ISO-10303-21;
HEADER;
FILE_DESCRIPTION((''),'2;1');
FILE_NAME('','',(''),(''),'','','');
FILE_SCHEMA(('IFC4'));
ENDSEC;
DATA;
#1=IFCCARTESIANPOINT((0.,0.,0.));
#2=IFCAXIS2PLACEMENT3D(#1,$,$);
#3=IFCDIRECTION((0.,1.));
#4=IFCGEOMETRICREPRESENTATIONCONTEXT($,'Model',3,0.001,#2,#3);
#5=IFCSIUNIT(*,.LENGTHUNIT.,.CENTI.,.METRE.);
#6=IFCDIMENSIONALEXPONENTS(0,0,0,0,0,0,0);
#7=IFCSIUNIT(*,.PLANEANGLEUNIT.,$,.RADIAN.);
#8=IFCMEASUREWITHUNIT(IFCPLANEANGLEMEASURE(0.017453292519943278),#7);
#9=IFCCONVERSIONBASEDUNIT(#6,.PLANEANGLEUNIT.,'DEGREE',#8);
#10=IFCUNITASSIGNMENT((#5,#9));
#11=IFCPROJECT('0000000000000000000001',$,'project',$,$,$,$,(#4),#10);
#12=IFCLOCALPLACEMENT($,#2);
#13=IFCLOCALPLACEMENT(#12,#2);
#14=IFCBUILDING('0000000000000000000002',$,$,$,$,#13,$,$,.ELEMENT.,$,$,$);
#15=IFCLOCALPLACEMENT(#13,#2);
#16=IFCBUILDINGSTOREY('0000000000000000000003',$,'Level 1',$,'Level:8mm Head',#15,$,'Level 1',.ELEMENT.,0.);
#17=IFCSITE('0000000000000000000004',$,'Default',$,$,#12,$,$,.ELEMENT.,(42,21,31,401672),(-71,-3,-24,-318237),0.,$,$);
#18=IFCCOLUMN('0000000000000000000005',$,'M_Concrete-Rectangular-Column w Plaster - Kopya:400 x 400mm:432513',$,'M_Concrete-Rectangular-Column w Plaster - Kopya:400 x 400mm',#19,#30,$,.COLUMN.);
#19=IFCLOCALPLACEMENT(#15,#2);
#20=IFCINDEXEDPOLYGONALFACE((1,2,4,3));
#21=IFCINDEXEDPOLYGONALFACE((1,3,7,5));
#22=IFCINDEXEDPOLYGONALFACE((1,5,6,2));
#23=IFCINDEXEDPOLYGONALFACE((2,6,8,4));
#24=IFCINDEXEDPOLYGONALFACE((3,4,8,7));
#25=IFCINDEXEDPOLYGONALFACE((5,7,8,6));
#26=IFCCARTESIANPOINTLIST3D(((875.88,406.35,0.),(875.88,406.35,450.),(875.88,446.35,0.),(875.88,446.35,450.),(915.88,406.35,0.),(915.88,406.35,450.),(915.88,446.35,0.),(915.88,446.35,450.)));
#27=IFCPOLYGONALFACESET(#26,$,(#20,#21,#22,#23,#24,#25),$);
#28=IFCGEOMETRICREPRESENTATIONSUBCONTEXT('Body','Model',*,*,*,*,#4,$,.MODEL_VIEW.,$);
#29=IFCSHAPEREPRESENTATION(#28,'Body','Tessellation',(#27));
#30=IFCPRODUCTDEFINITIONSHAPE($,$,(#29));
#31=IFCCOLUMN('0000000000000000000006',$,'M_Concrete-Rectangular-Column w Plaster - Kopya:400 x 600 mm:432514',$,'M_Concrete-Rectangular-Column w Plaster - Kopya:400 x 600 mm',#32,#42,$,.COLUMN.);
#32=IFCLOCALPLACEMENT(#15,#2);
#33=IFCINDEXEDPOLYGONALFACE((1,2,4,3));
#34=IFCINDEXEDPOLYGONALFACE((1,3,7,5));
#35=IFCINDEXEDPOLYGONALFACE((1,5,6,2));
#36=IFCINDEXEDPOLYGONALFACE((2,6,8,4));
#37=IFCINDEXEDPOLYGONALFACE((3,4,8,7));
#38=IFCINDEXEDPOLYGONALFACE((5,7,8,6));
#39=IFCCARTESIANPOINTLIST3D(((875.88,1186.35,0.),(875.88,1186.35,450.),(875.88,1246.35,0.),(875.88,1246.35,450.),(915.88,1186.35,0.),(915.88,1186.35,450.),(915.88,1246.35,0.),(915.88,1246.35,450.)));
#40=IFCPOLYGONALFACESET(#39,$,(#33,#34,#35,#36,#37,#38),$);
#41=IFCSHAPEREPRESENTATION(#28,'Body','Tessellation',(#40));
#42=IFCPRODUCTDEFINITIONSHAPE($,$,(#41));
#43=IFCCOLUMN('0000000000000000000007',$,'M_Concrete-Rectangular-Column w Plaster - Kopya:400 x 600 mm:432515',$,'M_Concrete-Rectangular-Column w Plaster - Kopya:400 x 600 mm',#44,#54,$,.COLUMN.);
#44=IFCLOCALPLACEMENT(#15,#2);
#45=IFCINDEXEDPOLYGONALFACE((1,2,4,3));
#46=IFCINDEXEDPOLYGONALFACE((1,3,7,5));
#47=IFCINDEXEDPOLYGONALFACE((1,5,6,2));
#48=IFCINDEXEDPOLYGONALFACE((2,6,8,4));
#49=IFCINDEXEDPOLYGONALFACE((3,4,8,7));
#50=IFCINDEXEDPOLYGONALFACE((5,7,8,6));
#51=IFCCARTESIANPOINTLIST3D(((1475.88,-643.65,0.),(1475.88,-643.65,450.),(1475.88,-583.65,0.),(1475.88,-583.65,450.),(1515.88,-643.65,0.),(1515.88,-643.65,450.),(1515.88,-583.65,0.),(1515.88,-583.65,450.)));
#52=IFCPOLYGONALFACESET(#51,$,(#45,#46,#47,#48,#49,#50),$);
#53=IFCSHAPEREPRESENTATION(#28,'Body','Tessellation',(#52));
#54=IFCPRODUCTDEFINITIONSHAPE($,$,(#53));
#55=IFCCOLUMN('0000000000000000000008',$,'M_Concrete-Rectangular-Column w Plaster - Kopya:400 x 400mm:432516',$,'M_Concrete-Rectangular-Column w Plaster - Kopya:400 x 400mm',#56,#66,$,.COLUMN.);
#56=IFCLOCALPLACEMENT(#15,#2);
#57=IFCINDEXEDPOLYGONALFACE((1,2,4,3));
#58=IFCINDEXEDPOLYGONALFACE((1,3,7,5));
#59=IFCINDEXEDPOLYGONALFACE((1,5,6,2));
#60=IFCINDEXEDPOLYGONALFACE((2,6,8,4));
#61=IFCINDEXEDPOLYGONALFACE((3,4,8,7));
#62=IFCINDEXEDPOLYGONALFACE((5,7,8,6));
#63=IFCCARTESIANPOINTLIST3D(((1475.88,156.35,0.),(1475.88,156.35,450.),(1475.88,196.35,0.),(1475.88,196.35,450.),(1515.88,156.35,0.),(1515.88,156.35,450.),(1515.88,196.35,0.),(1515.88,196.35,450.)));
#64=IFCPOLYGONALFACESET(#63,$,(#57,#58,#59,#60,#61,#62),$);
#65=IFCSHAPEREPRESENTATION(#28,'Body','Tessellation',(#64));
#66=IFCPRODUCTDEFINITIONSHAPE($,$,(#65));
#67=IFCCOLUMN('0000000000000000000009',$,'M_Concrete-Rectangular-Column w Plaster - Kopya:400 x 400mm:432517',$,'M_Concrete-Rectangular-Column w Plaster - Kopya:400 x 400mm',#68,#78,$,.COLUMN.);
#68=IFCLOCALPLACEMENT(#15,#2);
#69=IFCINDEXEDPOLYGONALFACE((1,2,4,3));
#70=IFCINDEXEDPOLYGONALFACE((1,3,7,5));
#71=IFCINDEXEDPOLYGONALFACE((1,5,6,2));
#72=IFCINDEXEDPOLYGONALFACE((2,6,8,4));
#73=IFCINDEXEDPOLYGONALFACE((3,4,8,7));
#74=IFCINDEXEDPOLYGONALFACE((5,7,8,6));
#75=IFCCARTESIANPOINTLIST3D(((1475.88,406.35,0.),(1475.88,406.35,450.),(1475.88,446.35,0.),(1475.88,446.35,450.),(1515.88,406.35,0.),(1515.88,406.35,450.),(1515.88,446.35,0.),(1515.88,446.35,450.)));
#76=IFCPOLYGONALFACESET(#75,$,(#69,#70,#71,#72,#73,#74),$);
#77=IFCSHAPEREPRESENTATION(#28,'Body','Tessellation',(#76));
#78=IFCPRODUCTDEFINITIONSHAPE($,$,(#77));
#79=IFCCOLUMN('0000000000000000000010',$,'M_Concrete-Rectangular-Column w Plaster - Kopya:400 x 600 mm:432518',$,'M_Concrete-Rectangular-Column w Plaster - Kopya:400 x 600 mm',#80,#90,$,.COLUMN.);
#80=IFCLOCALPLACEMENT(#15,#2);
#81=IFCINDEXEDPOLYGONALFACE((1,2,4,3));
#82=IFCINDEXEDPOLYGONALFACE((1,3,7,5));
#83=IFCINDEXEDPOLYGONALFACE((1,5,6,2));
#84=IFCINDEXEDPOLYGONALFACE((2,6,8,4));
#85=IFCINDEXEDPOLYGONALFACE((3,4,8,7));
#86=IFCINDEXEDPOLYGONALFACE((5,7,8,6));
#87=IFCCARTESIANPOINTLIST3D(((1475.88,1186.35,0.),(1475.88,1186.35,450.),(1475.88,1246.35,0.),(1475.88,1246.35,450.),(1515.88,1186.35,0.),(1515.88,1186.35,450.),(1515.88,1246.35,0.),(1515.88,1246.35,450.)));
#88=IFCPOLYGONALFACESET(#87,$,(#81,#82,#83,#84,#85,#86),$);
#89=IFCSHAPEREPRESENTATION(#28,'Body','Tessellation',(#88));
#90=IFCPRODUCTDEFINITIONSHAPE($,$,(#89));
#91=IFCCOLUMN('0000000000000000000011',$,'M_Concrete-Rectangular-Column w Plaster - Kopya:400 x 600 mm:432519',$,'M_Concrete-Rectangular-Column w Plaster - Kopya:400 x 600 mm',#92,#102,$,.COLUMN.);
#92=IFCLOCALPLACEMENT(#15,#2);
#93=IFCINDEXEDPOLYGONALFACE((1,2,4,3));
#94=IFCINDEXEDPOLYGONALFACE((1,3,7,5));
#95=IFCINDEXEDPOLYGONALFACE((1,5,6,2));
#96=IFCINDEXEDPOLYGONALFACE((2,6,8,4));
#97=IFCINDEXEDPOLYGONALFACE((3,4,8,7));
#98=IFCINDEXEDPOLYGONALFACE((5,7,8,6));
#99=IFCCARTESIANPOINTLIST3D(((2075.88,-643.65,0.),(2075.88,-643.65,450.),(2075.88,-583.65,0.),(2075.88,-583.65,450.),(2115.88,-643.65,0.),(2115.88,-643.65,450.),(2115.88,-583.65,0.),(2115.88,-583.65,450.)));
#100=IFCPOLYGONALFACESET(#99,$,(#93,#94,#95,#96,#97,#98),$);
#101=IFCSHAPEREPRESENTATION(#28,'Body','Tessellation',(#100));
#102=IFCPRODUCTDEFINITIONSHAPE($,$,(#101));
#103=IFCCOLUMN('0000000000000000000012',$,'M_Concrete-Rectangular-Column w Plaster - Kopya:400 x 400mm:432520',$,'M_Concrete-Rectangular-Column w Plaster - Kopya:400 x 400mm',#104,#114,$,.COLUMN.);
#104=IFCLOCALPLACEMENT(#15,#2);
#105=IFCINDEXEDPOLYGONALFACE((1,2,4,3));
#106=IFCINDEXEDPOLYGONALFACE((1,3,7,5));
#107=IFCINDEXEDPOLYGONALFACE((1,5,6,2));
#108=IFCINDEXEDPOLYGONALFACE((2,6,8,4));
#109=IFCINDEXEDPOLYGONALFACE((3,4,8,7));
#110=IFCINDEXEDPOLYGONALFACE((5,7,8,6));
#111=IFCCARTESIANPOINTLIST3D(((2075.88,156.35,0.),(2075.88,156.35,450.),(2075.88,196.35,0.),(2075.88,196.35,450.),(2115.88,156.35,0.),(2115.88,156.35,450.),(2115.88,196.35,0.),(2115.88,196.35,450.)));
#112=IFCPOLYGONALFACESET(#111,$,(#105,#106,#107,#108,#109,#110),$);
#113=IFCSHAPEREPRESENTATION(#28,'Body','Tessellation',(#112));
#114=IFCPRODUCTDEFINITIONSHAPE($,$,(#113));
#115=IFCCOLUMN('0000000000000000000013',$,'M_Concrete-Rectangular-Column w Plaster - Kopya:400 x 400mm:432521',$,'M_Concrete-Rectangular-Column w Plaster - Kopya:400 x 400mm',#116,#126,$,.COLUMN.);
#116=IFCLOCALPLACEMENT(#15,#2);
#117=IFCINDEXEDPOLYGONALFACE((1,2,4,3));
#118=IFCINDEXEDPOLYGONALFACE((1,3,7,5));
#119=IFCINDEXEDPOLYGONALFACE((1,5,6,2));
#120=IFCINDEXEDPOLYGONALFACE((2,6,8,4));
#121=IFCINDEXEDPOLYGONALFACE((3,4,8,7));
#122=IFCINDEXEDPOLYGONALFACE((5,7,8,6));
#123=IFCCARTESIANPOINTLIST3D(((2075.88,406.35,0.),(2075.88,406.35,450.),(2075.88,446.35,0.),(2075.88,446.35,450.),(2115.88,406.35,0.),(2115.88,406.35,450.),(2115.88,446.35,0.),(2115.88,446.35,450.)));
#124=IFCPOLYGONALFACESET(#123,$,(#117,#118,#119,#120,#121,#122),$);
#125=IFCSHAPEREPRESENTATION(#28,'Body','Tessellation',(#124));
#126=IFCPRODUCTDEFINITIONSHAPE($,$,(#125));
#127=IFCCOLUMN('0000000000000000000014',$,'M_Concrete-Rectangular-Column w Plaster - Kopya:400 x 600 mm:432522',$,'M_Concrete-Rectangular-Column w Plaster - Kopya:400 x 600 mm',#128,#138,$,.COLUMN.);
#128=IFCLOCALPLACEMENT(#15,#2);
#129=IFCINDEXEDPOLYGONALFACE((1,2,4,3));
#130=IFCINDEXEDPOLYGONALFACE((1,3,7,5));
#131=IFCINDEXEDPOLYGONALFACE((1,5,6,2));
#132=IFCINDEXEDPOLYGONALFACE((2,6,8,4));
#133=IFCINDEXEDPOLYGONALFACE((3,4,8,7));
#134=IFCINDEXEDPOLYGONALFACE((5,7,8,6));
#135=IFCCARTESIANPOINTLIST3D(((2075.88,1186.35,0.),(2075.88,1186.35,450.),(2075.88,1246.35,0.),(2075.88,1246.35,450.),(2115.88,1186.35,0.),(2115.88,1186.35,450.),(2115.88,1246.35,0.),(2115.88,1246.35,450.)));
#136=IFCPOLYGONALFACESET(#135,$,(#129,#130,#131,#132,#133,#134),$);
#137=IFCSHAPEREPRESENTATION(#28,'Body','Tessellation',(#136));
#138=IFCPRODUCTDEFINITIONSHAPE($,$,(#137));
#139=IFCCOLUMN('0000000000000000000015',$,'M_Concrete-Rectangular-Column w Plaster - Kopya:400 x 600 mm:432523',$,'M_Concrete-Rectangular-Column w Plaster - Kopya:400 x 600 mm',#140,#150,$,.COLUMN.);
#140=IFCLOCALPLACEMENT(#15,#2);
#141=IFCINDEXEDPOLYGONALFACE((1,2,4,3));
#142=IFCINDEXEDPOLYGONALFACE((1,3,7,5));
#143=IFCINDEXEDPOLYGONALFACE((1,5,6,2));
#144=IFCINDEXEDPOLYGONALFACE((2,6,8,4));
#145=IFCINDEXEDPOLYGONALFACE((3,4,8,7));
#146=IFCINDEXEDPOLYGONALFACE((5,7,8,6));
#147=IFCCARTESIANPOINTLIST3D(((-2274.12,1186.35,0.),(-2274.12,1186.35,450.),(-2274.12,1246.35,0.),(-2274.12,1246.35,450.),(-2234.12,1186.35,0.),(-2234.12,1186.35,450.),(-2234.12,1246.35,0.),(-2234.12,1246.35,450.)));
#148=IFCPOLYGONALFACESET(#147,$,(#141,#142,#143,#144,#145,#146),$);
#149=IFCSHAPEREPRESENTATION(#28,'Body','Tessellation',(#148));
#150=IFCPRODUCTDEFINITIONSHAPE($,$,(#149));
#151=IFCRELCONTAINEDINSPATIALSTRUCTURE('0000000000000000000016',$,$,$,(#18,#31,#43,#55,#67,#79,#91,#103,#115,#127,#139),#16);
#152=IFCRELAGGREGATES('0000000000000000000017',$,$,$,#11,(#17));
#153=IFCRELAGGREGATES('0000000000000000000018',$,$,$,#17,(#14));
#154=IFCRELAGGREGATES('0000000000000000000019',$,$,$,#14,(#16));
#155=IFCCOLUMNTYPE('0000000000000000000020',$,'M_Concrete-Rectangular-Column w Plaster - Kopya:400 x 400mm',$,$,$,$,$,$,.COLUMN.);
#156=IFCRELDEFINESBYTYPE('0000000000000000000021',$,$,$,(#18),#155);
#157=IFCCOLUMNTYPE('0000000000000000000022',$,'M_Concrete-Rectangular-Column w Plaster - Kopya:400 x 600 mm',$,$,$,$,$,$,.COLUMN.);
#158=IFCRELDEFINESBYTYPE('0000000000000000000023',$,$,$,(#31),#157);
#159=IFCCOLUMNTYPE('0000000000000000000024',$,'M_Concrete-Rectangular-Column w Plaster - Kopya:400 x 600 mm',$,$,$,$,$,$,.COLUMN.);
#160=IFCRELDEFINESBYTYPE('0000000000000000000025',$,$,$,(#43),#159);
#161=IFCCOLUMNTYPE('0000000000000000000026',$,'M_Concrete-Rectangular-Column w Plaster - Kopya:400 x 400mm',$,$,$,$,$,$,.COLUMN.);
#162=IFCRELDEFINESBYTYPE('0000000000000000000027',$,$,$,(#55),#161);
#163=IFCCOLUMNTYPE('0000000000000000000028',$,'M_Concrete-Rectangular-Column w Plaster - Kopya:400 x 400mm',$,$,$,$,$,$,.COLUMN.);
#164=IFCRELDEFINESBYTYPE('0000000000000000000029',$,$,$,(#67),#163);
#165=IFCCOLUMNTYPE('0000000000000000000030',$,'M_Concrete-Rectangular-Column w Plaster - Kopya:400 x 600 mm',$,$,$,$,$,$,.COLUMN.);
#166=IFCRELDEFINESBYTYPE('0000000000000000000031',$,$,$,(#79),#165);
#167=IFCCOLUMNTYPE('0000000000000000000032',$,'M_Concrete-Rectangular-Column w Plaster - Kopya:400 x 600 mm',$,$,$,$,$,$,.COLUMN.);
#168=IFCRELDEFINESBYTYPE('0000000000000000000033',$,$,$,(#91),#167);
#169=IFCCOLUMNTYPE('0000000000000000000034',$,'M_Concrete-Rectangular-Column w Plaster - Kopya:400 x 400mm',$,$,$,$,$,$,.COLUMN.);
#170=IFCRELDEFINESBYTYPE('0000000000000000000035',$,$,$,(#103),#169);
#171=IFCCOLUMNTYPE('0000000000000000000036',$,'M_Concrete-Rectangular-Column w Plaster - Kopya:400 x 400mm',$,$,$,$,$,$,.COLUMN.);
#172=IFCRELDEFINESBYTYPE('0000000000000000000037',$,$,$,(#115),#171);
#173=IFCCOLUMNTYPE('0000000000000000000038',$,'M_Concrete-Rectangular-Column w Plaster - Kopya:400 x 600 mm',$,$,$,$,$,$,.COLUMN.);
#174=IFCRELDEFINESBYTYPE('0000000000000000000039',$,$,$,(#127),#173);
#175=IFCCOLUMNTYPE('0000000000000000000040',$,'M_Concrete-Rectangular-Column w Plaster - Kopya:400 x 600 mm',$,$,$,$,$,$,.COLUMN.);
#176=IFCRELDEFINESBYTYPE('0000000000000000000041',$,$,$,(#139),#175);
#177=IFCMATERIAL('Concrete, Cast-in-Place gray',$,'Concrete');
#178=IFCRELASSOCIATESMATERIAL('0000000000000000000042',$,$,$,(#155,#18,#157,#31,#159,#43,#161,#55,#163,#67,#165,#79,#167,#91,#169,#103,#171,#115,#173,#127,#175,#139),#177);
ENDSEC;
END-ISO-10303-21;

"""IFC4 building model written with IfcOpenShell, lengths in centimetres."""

from ifc_helpers import new_model, entity, si_unit, converted_unit, direction, frame, origin, place, context, subcontext, project, spatial, indexed_curve, outline, extrude, source, transform, mapped, material, type_object, type_shapes, element, save


model = new_model("IFC4")

# Units and contexts
model_context = context("Model", 3, precision=0.001, world=origin(), true_north=direction((0.0, 1.0)))
body_context = subcontext(model_context, "Body", "Model", "MODEL_VIEW")
ifc_project = project(units=[si_unit("LENGTHUNIT", "METRE", prefix="CENTI"), converted_unit("PLANEANGLEUNIT", "DEGREE", entity("IfcPlaneAngleMeasure", 0.017453292519943278), si_unit("PLANEANGLEUNIT", "RADIAN"), dimensions=[0, 0, 0, 0, 0, 0, 0])], contexts=[model_context])

# Site, building, storey
site_placement = place(None, origin())
site = spatial("IfcSite", under=ifc_project, at=site_placement, Name="Default", CompositionType="ELEMENT", RefLatitude=(42, 21, 31, 401672), RefLongitude=(-71, -3, -24, -318237), RefElevation=0.0)
building_placement = place(site_placement, origin())
building = spatial("IfcBuilding", under=site, at=building_placement, CompositionType="ELEMENT")
storey_placement = place(building_placement, origin())
storey = spatial("IfcBuildingStorey", under=building, at=storey_placement, Name="Level 1", ObjectType="Level:8mm Head", LongName="Level 1", CompositionType="ELEMENT", Elevation=0.0)

# Columns
ifc_material = material(Name="Concrete, Cast-in-Place gray", Category="Concrete")
column_type_1 = type_object("IfcColumnType", Name="M_Concrete-Rectangular-Column w Plaster - Kopya:400 x 400mm", PredefinedType="COLUMN", material=ifc_material)
shared_shape_1 = source(origin(), body_context, "Body", "SweptSolid", [
    extrude(outline(indexed_curve([(-20.0, -20.0), (20.0, -20.0), (20.0, 20.0), (-20.0, 20.0), (-20.0, -20.0)], self_intersect=False)), frame((895.88, 426.35, 0.0), z_axis=(0.0, 0.0, 1.0), x_axis=(-1.0, 0.0, 0.0)), (0.0, 0.0, 1.0), 450.0),
])
type_shapes(column_type_1, [shared_shape_1])
column_1_placement = place(storey_placement, origin())
element("IfcColumn", 1, at=column_1_placement, inside=storey, type_object=column_type_1, material=ifc_material, Name="M_Concrete-Rectangular-Column w Plaster - Kopya:400 x 400mm:432513", ObjectType="M_Concrete-Rectangular-Column w Plaster - Kopya:400 x 400mm", PredefinedType="COLUMN", context=body_context, shape_type="MappedRepresentation", body=[
    mapped(shared_shape_1, transform((0.0, 0.0, 0.0), scale=1.0)),
])
column_type_2 = type_object("IfcColumnType", Name="M_Concrete-Rectangular-Column w Plaster - Kopya:400 x 600 mm", PredefinedType="COLUMN", material=ifc_material)
shared_shape_2 = source(origin(), body_context, "Body", "SweptSolid", [
    extrude(outline(indexed_curve([(-20.0, -30.0), (20.0, -30.0), (20.0, 30.0), (-20.0, 30.0), (-20.0, -30.0)], self_intersect=False)), frame((895.88, 1216.35, 0.0)), (0.0, 0.0, 1.0), 450.0),
])
type_shapes(column_type_2, [shared_shape_2])
column_2_placement = place(storey_placement, origin())
element("IfcColumn", 2, at=column_2_placement, inside=storey, type_object=column_type_2, material=ifc_material, Name="M_Concrete-Rectangular-Column w Plaster - Kopya:400 x 600 mm:432514", ObjectType="M_Concrete-Rectangular-Column w Plaster - Kopya:400 x 600 mm", PredefinedType="COLUMN", context=body_context, shape_type="MappedRepresentation", body=[
    mapped(shared_shape_2, transform((0.0, 0.0, 0.0), scale=1.0)),
])
column_type_3 = type_object("IfcColumnType", Name="M_Concrete-Rectangular-Column w Plaster - Kopya:400 x 600 mm", PredefinedType="COLUMN", material=ifc_material)
shared_shape_3 = source(origin(), body_context, "Body", "SweptSolid", [
    extrude(outline(indexed_curve([(-20.0, -30.0), (20.0, -30.0), (20.0, 30.0), (-20.0, 30.0), (-20.0, -30.0)], self_intersect=False)), frame((1495.88, -613.65, 0.0), z_axis=(0.0, 0.0, 1.0), x_axis=(-1.0, 0.0, 0.0)), (0.0, 0.0, 1.0), 450.0),
])
type_shapes(column_type_3, [shared_shape_3])
column_3_placement = place(storey_placement, origin())
element("IfcColumn", 3, at=column_3_placement, inside=storey, type_object=column_type_3, material=ifc_material, Name="M_Concrete-Rectangular-Column w Plaster - Kopya:400 x 600 mm:432515", ObjectType="M_Concrete-Rectangular-Column w Plaster - Kopya:400 x 600 mm", PredefinedType="COLUMN", context=body_context, shape_type="MappedRepresentation", body=[
    mapped(shared_shape_3, transform((0.0, 0.0, 0.0), scale=1.0)),
])
column_type_4 = type_object("IfcColumnType", Name="M_Concrete-Rectangular-Column w Plaster - Kopya:400 x 400mm", PredefinedType="COLUMN", material=ifc_material)
shared_shape_4 = source(origin(), body_context, "Body", "SweptSolid", [
    extrude(outline(indexed_curve([(-20.0, -20.0), (20.0, -20.0), (20.0, 20.0), (-20.0, 20.0), (-20.0, -20.0)], self_intersect=False)), frame((1495.88, 176.35, 0.0), z_axis=(0.0, 0.0, 1.0), x_axis=(-1.0, 0.0, 0.0)), (0.0, 0.0, 1.0), 450.0),
])
type_shapes(column_type_4, [shared_shape_4])
column_4_placement = place(storey_placement, origin())
element("IfcColumn", 4, at=column_4_placement, inside=storey, type_object=column_type_4, material=ifc_material, Name="M_Concrete-Rectangular-Column w Plaster - Kopya:400 x 400mm:432516", ObjectType="M_Concrete-Rectangular-Column w Plaster - Kopya:400 x 400mm", PredefinedType="COLUMN", context=body_context, shape_type="MappedRepresentation", body=[
    mapped(shared_shape_4, transform((0.0, 0.0, 0.0), scale=1.0)),
])
column_type_5 = type_object("IfcColumnType", Name="M_Concrete-Rectangular-Column w Plaster - Kopya:400 x 400mm", PredefinedType="COLUMN", material=ifc_material)
shared_shape_5 = source(origin(), body_context, "Body", "SweptSolid", [
    extrude(outline(indexed_curve([(-20.0, -20.0), (20.0, -20.0), (20.0, 20.0), (-20.0, 20.0), (-20.0, -20.0)], self_intersect=False)), frame((1495.88, 426.35, 0.0), z_axis=(0.0, 0.0, 1.0), x_axis=(-1.0, 0.0, 0.0)), (0.0, 0.0, 1.0), 450.0),
])
type_shapes(column_type_5, [shared_shape_5])
column_5_placement = place(storey_placement, origin())
element("IfcColumn", 5, at=column_5_placement, inside=storey, type_object=column_type_5, material=ifc_material, Name="M_Concrete-Rectangular-Column w Plaster - Kopya:400 x 400mm:432517", ObjectType="M_Concrete-Rectangular-Column w Plaster - Kopya:400 x 400mm", PredefinedType="COLUMN", context=body_context, shape_type="MappedRepresentation", body=[
    mapped(shared_shape_5, transform((0.0, 0.0, 0.0), scale=1.0)),
])
column_type_6 = type_object("IfcColumnType", Name="M_Concrete-Rectangular-Column w Plaster - Kopya:400 x 600 mm", PredefinedType="COLUMN", material=ifc_material)
shared_shape_6 = source(origin(), body_context, "Body", "SweptSolid", [
    extrude(outline(indexed_curve([(-20.0, -30.0), (20.0, -30.0), (20.0, 30.0), (-20.0, 30.0), (-20.0, -30.0)], self_intersect=False)), frame((1495.88, 1216.35, 0.0)), (0.0, 0.0, 1.0), 450.0),
])
type_shapes(column_type_6, [shared_shape_6])
column_6_placement = place(storey_placement, origin())
element("IfcColumn", 6, at=column_6_placement, inside=storey, type_object=column_type_6, material=ifc_material, Name="M_Concrete-Rectangular-Column w Plaster - Kopya:400 x 600 mm:432518", ObjectType="M_Concrete-Rectangular-Column w Plaster - Kopya:400 x 600 mm", PredefinedType="COLUMN", context=body_context, shape_type="MappedRepresentation", body=[
    mapped(shared_shape_6, transform((0.0, 0.0, 0.0), scale=1.0)),
])
column_type_7 = type_object("IfcColumnType", Name="M_Concrete-Rectangular-Column w Plaster - Kopya:400 x 600 mm", PredefinedType="COLUMN", material=ifc_material)
shared_shape_7 = source(origin(), body_context, "Body", "SweptSolid", [
    extrude(outline(indexed_curve([(-20.0, -30.0), (20.0, -30.0), (20.0, 30.0), (-20.0, 30.0), (-20.0, -30.0)], self_intersect=False)), frame((2095.88, -613.65, 0.0)), (0.0, 0.0, 1.0), 450.0),
])
type_shapes(column_type_7, [shared_shape_7])
column_7_placement = place(storey_placement, origin())
element("IfcColumn", 7, at=column_7_placement, inside=storey, type_object=column_type_7, material=ifc_material, Name="M_Concrete-Rectangular-Column w Plaster - Kopya:400 x 600 mm:432519", ObjectType="M_Concrete-Rectangular-Column w Plaster - Kopya:400 x 600 mm", PredefinedType="COLUMN", context=body_context, shape_type="MappedRepresentation", body=[
    mapped(shared_shape_7, transform((0.0, 0.0, 0.0), scale=1.0)),
])
column_type_8 = type_object("IfcColumnType", Name="M_Concrete-Rectangular-Column w Plaster - Kopya:400 x 400mm", PredefinedType="COLUMN", material=ifc_material)
shared_shape_8 = source(origin(), body_context, "Body", "SweptSolid", [
    extrude(outline(indexed_curve([(-20.0, -20.0), (20.0, -20.0), (20.0, 20.0), (-20.0, 20.0), (-20.0, -20.0)], self_intersect=False)), frame((2095.88, 176.35, 0.0), z_axis=(0.0, 0.0, 1.0), x_axis=(-1.0, 0.0, 0.0)), (0.0, 0.0, 1.0), 450.0),
])
type_shapes(column_type_8, [shared_shape_8])
column_8_placement = place(storey_placement, origin())
element("IfcColumn", 8, at=column_8_placement, inside=storey, type_object=column_type_8, material=ifc_material, Name="M_Concrete-Rectangular-Column w Plaster - Kopya:400 x 400mm:432520", ObjectType="M_Concrete-Rectangular-Column w Plaster - Kopya:400 x 400mm", PredefinedType="COLUMN", context=body_context, shape_type="MappedRepresentation", body=[
    mapped(shared_shape_8, transform((0.0, 0.0, 0.0), scale=1.0)),
])
column_type_9 = type_object("IfcColumnType", Name="M_Concrete-Rectangular-Column w Plaster - Kopya:400 x 400mm", PredefinedType="COLUMN", material=ifc_material)
shared_shape_9 = source(origin(), body_context, "Body", "SweptSolid", [
    extrude(outline(indexed_curve([(-20.0, -20.0), (20.0, -20.0), (20.0, 20.0), (-20.0, 20.0), (-20.0, -20.0)], self_intersect=False)), frame((2095.88, 426.35, 0.0), z_axis=(0.0, 0.0, 1.0), x_axis=(-1.0, 0.0, 0.0)), (0.0, 0.0, 1.0), 450.0),
])
type_shapes(column_type_9, [shared_shape_9])
column_9_placement = place(storey_placement, origin())
element("IfcColumn", 9, at=column_9_placement, inside=storey, type_object=column_type_9, material=ifc_material, Name="M_Concrete-Rectangular-Column w Plaster - Kopya:400 x 400mm:432521", ObjectType="M_Concrete-Rectangular-Column w Plaster - Kopya:400 x 400mm", PredefinedType="COLUMN", context=body_context, shape_type="MappedRepresentation", body=[
    mapped(shared_shape_9, transform((0.0, 0.0, 0.0), scale=1.0)),
])
column_type_10 = type_object("IfcColumnType", Name="M_Concrete-Rectangular-Column w Plaster - Kopya:400 x 600 mm", PredefinedType="COLUMN", material=ifc_material)
shared_shape_10 = source(origin(), body_context, "Body", "SweptSolid", [
    extrude(outline(indexed_curve([(-20.0, -30.0), (20.0, -30.0), (20.0, 30.0), (-20.0, 30.0), (-20.0, -30.0)], self_intersect=False)), frame((2095.88, 1216.35, 0.0), z_axis=(0.0, 0.0, 1.0), x_axis=(-1.0, 0.0, 0.0)), (0.0, 0.0, 1.0), 450.0),
])
type_shapes(column_type_10, [shared_shape_10])
column_10_placement = place(storey_placement, origin())
element("IfcColumn", 10, at=column_10_placement, inside=storey, type_object=column_type_10, material=ifc_material, Name="M_Concrete-Rectangular-Column w Plaster - Kopya:400 x 600 mm:432522", ObjectType="M_Concrete-Rectangular-Column w Plaster - Kopya:400 x 600 mm", PredefinedType="COLUMN", context=body_context, shape_type="MappedRepresentation", body=[
    mapped(shared_shape_10, transform((0.0, 0.0, 0.0), scale=1.0)),
])
column_type_11 = type_object("IfcColumnType", Name="M_Concrete-Rectangular-Column w Plaster - Kopya:400 x 600 mm", PredefinedType="COLUMN", material=ifc_material)
shared_shape_11 = source(origin(), body_context, "Body", "SweptSolid", [
    extrude(outline(indexed_curve([(-20.0, -30.0), (20.0, -30.0), (20.0, 30.0), (-20.0, 30.0), (-20.0, -30.0)], self_intersect=False)), frame((-2254.12, 1216.35, 0.0), z_axis=(0.0, 0.0, 1.0), x_axis=(-1.0, 0.0, 0.0)), (0.0, 0.0, 1.0), 450.0),
])
type_shapes(column_type_11, [shared_shape_11])
column_11_placement = place(storey_placement, origin())
element("IfcColumn", 11, at=column_11_placement, inside=storey, type_object=column_type_11, material=ifc_material, Name="M_Concrete-Rectangular-Column w Plaster - Kopya:400 x 600 mm:432523", ObjectType="M_Concrete-Rectangular-Column w Plaster - Kopya:400 x 600 mm", PredefinedType="COLUMN", context=body_context, shape_type="MappedRepresentation", body=[
    mapped(shared_shape_11, transform((0.0, 0.0, 0.0), scale=1.0)),
])

save(model, "model.ifc")
